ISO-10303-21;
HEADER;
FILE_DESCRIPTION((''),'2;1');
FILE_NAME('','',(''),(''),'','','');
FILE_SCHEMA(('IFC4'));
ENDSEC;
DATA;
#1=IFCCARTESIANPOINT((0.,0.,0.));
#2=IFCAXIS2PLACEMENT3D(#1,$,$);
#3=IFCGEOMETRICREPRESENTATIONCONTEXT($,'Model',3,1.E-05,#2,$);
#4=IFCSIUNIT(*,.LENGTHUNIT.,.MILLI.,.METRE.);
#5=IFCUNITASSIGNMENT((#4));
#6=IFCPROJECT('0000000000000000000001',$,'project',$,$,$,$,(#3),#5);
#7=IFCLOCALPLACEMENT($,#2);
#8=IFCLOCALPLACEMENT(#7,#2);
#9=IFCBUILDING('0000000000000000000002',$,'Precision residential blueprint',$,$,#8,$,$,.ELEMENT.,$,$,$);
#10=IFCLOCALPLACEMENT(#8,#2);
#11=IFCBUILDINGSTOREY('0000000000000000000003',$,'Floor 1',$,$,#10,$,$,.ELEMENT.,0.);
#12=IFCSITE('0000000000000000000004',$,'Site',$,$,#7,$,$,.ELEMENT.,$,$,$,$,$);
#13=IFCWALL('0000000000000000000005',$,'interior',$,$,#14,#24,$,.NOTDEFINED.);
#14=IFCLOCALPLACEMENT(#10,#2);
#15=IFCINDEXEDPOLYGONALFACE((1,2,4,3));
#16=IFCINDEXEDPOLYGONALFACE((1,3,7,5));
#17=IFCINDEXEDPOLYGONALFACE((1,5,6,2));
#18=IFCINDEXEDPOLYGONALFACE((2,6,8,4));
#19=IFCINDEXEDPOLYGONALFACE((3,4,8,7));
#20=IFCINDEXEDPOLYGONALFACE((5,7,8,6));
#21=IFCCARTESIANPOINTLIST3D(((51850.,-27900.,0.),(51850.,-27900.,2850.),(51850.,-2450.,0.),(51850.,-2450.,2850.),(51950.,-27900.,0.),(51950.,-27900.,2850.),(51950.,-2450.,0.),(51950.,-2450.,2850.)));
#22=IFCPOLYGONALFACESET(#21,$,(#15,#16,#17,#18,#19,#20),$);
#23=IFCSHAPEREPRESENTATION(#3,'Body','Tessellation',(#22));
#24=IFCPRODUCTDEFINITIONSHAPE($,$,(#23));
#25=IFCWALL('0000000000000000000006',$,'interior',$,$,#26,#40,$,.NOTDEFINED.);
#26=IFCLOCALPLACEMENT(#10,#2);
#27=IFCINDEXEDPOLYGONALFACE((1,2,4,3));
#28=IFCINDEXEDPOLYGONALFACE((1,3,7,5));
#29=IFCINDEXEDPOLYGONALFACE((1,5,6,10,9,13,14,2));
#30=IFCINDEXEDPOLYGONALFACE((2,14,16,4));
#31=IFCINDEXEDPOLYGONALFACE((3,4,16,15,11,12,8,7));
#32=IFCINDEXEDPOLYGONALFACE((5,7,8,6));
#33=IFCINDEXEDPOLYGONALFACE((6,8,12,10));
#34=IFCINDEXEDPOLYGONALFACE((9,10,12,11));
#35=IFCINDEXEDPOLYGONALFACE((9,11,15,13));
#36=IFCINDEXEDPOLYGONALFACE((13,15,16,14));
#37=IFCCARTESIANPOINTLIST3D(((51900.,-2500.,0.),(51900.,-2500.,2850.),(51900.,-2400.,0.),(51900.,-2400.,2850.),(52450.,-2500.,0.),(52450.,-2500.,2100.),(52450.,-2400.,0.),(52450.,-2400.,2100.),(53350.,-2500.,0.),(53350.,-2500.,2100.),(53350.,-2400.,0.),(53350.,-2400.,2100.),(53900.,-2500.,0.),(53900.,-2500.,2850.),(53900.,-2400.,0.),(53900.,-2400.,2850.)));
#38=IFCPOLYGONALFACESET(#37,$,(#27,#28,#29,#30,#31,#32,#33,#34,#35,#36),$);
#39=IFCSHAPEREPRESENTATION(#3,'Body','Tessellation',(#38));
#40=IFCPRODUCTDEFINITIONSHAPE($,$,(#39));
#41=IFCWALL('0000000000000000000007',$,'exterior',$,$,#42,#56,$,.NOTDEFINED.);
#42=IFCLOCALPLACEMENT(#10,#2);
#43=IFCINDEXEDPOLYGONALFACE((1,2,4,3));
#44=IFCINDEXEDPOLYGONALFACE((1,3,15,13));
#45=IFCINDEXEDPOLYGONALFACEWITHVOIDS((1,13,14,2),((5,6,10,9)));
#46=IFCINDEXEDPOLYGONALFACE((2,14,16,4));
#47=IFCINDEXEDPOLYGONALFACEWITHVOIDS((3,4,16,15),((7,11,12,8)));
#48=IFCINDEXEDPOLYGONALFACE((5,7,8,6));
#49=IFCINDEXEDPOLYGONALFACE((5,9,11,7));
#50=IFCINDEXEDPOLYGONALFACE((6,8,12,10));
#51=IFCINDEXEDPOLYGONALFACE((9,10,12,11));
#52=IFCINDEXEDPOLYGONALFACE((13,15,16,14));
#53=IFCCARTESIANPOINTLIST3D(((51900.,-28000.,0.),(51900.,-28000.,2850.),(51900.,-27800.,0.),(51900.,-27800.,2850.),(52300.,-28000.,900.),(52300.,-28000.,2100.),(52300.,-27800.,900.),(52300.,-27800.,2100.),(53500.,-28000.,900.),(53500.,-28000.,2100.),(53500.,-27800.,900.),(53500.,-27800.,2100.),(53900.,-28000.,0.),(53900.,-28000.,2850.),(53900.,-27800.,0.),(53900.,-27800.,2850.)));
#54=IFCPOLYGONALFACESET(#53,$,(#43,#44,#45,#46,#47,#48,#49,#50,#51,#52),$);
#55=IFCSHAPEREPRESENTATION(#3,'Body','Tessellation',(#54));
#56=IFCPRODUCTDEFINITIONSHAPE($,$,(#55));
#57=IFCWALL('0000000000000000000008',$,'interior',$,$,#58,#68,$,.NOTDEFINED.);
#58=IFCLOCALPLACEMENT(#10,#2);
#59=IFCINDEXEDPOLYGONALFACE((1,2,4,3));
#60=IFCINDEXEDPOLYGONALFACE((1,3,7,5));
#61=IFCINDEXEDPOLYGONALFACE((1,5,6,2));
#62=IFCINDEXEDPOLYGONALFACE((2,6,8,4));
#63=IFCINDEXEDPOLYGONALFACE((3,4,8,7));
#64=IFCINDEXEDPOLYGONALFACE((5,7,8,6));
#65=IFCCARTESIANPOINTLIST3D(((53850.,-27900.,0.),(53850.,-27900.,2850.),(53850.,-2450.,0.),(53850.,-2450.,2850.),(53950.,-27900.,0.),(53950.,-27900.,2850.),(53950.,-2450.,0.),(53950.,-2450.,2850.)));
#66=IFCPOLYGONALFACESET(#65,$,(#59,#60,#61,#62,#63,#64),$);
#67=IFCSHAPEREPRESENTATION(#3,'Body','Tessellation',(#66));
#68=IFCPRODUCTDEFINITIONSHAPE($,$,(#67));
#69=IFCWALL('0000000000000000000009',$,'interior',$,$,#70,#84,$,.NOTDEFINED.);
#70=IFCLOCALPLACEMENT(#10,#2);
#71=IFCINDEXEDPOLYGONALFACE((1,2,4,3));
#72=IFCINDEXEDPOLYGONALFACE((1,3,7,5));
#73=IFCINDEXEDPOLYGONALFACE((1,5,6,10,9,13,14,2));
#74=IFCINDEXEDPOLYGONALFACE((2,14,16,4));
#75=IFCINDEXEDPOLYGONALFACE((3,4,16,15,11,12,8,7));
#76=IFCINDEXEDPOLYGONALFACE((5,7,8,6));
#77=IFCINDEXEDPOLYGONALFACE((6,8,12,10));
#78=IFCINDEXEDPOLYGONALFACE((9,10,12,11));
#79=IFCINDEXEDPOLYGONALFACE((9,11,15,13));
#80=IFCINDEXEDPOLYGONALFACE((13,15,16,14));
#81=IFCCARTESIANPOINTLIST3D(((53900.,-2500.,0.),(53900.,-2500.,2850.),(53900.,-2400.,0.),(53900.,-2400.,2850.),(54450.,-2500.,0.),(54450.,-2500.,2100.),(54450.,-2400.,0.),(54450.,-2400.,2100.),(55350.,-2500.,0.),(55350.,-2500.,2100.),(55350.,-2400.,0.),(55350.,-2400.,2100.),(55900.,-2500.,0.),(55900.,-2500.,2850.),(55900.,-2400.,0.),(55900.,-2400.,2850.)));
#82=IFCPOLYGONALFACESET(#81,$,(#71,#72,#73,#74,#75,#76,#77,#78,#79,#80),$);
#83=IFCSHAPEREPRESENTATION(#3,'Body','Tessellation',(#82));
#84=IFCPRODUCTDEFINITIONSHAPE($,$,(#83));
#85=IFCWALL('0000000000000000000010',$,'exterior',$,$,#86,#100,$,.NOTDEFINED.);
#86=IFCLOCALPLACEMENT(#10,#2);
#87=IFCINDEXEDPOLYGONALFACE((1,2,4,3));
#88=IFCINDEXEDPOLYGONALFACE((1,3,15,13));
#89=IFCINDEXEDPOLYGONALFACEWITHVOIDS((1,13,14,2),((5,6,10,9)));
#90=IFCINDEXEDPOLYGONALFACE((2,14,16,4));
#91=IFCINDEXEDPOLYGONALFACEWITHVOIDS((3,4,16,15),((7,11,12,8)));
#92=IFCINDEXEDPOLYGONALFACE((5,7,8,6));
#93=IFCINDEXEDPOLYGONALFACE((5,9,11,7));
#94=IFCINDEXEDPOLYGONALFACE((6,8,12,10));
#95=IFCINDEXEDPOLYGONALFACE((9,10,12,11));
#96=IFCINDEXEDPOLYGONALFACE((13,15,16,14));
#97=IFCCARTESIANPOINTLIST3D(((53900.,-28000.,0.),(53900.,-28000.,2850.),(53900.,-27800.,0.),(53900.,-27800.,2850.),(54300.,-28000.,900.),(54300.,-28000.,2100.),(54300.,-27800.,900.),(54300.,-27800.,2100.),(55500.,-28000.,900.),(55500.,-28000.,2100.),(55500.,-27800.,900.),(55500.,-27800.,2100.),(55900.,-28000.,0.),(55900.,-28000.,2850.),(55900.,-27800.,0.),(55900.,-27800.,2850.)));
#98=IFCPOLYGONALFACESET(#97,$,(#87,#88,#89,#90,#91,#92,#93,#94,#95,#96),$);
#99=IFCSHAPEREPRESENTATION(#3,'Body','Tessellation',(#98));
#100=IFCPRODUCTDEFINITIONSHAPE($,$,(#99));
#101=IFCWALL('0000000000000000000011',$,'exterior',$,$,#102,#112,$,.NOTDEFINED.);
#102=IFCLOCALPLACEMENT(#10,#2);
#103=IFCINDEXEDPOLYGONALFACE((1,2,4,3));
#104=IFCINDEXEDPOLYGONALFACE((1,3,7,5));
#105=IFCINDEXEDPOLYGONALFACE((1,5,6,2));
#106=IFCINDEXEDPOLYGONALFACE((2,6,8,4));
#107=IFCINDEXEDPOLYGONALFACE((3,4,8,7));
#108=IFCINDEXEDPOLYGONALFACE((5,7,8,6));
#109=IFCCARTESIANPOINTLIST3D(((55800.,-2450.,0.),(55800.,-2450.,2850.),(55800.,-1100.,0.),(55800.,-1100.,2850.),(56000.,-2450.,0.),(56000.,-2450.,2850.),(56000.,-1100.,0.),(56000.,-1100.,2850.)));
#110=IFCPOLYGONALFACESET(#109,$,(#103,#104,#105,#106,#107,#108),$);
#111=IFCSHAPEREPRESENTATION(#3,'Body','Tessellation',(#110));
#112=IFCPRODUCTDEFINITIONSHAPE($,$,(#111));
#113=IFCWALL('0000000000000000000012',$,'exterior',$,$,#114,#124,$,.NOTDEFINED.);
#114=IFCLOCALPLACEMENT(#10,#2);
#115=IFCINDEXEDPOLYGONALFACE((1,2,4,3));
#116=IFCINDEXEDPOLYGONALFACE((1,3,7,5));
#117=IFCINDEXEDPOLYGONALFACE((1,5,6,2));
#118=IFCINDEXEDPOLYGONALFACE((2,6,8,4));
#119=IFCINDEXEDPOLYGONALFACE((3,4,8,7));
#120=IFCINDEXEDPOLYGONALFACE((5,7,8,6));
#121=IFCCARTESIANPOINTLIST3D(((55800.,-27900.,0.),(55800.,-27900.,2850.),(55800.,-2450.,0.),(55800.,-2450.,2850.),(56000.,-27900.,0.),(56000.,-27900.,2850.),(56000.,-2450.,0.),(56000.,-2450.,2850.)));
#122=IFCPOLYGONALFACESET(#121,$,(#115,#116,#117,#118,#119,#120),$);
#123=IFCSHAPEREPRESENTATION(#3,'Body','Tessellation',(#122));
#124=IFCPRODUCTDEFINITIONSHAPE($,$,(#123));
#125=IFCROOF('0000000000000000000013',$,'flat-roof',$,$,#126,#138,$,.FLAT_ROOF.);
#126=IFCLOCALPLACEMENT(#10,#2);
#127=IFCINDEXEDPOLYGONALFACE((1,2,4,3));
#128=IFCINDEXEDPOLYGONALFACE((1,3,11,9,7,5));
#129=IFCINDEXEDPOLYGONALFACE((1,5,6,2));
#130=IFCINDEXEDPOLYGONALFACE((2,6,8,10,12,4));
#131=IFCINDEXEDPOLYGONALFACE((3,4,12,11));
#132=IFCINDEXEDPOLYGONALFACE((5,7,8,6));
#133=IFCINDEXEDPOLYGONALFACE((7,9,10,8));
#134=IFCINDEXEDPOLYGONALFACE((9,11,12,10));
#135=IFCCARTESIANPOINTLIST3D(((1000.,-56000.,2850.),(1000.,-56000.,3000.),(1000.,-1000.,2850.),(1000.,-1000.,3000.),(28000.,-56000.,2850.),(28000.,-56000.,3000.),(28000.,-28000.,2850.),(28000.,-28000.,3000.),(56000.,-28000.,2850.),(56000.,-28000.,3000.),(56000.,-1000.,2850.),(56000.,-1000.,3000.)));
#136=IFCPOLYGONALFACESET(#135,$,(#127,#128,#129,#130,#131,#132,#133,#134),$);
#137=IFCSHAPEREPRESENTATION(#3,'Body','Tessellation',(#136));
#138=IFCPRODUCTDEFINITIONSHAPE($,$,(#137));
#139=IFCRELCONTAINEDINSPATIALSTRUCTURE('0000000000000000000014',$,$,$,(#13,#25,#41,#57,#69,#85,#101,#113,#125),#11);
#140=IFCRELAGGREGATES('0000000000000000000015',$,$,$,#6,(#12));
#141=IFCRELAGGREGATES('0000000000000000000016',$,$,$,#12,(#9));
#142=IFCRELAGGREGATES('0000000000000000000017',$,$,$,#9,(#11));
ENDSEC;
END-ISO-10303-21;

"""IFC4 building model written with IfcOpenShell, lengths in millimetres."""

from ifc_helpers import new_model, si_unit, frame, origin, place, context, project, spatial, polyline, outline, extrude, element, save


model = new_model("IFC4")

# Units and contexts
model_context = context("Model", 3, precision=1e-05, world=origin())
ifc_project = project(units=[si_unit("LENGTHUNIT", "METRE", prefix="MILLI")], contexts=[model_context])

# Site, building, storey
site_placement = place(None, origin())
site = spatial("IfcSite", under=ifc_project, at=site_placement, Name="Site", CompositionType="ELEMENT")
building_placement = place(site_placement, origin())
building = spatial("IfcBuilding", under=site, at=building_placement, Name="Precision residential blueprint", CompositionType="ELEMENT")
storey_placement = place(building_placement, origin())
storey = spatial("IfcBuildingStorey", under=building, at=storey_placement, Name="Floor 1", CompositionType="ELEMENT", Elevation=0.0)

# Wall
wall_1_placement = place(storey_placement, origin())
element("IfcWall", 1, at=wall_1_placement, inside=storey, Name="interior", PredefinedType="NOTDEFINED", context=model_context, shape_type="SweptSolid", body=[
    extrude(outline(polyline([(51950.0, -2450.0), (51950.0, -27900.0), (51850.0, -27900.0), (51850.0, -2450.0), (51950.0, -2450.0)])), origin(), (0.0, 0.0, 1.0), 2850.0),
])

# Walls, openings
wall_2_placement = place(storey_placement, origin())
wall_2 = element("IfcWall", 2, at=wall_2_placement, inside=storey, Name="interior", PredefinedType="NOTDEFINED", context=model_context, shape_type="SweptSolid", body=[
    extrude(outline(polyline([(51900.0, -2400.0), (53900.0, -2400.0), (53900.0, -2500.0), (51900.0, -2500.0), (51900.0, -2400.0)])), origin(), (0.0, 0.0, 1.0), 2850.0),
])
opening_1_placement = place(storey_placement, origin())
element("IfcOpeningElement", 3, at=opening_1_placement, cuts=wall_2, PredefinedType="OPENING", context=model_context, shape_type="SweptSolid", body=[
    extrude(outline(polyline([(52450.0, -2400.0), (53350.0, -2400.0), (53350.0, -2500.0), (52450.0, -2500.0), (52450.0, -2400.0)])), origin(), (0.0, 0.0, 1.0), 2100.0),
])
wall_3_placement = place(storey_placement, origin())
wall_3 = element("IfcWall", 4, at=wall_3_placement, inside=storey, Name="exterior", PredefinedType="NOTDEFINED", context=model_context, shape_type="SweptSolid", body=[
    extrude(outline(polyline([(51900.0, -27800.0), (53900.0, -27800.0), (53900.0, -28000.0), (51900.0, -28000.0), (51900.0, -27800.0)])), origin(), (0.0, 0.0, 1.0), 2850.0),
])
opening_2_placement = place(storey_placement, origin())
element("IfcOpeningElement", 5, at=opening_2_placement, cuts=wall_3, PredefinedType="OPENING", context=model_context, shape_type="SweptSolid", body=[
    extrude(outline(polyline([(52300.0, -27800.0), (53500.0, -27800.0), (53500.0, -28000.0), (52300.0, -28000.0), (52300.0, -27800.0)])), frame((0.0, 0.0, 900.0)), (0.0, 0.0, 1.0), 1200.0),
])

# Wall
wall_4_placement = place(storey_placement, origin())
element("IfcWall", 6, at=wall_4_placement, inside=storey, Name="interior", PredefinedType="NOTDEFINED", context=model_context, shape_type="SweptSolid", body=[
    extrude(outline(polyline([(53950.0, -2450.0), (53950.0, -27900.0), (53850.0, -27900.0), (53850.0, -2450.0), (53950.0, -2450.0)])), origin(), (0.0, 0.0, 1.0), 2850.0),
])

# Walls, openings
wall_5_placement = place(storey_placement, origin())
wall_5 = element("IfcWall", 7, at=wall_5_placement, inside=storey, Name="interior", PredefinedType="NOTDEFINED", context=model_context, shape_type="SweptSolid", body=[
    extrude(outline(polyline([(53900.0, -2400.0), (55900.0, -2400.0), (55900.0, -2500.0), (53900.0, -2500.0), (53900.0, -2400.0)])), origin(), (0.0, 0.0, 1.0), 2850.0),
])
opening_3_placement = place(storey_placement, origin())
element("IfcOpeningElement", 8, at=opening_3_placement, cuts=wall_5, PredefinedType="OPENING", context=model_context, shape_type="SweptSolid", body=[
    extrude(outline(polyline([(54450.0, -2400.0), (55350.0, -2400.0), (55350.0, -2500.0), (54450.0, -2500.0), (54450.0, -2400.0)])), origin(), (0.0, 0.0, 1.0), 2100.0),
])
wall_6_placement = place(storey_placement, origin())
wall_6 = element("IfcWall", 9, at=wall_6_placement, inside=storey, Name="exterior", PredefinedType="NOTDEFINED", context=model_context, shape_type="SweptSolid", body=[
    extrude(outline(polyline([(53900.0, -27800.0), (55900.0, -27800.0), (55900.0, -28000.0), (53900.0, -28000.0), (53900.0, -27800.0)])), origin(), (0.0, 0.0, 1.0), 2850.0),
])
opening_4_placement = place(storey_placement, origin())
element("IfcOpeningElement", 10, at=opening_4_placement, cuts=wall_6, PredefinedType="OPENING", context=model_context, shape_type="SweptSolid", body=[
    extrude(outline(polyline([(54300.0, -27800.0), (55500.0, -27800.0), (55500.0, -28000.0), (54300.0, -28000.0), (54300.0, -27800.0)])), frame((0.0, 0.0, 900.0)), (0.0, 0.0, 1.0), 1200.0),
])

# Walls
wall_7_placement = place(storey_placement, origin())
element("IfcWall", 11, at=wall_7_placement, inside=storey, Name="exterior", PredefinedType="NOTDEFINED", context=model_context, shape_type="SweptSolid", body=[
    extrude(outline(polyline([(56000.0, -1100.0), (56000.0, -2450.0), (55800.0, -2450.0), (55800.0, -1100.0), (56000.0, -1100.0)])), origin(), (0.0, 0.0, 1.0), 2850.0),
])
wall_8_placement = place(storey_placement, origin())
element("IfcWall", 12, at=wall_8_placement, inside=storey, Name="exterior", PredefinedType="NOTDEFINED", context=model_context, shape_type="SweptSolid", body=[
    extrude(outline(polyline([(56000.0, -2450.0), (56000.0, -27900.0), (55800.0, -27900.0), (55800.0, -2450.0), (56000.0, -2450.0)])), origin(), (0.0, 0.0, 1.0), 2850.0),
])

# Roof
roof_placement = place(storey_placement, origin())
element("IfcRoof", 13, at=roof_placement, inside=storey, Name="flat-roof", PredefinedType="FLAT_ROOF", context=model_context, shape_type="SweptSolid", body=[
    extrude(outline(polyline([(1000.0, -56000.0), (28000.0, -56000.0), (28000.0, -28000.0), (56000.0, -28000.0), (56000.0, -1000.0), (1000.0, -1000.0), (1000.0, -56000.0)])), frame((0.0, 0.0, 2850.0)), (0.0, 0.0, 1.0), 150.0),
])

save(model, "model.ifc")
